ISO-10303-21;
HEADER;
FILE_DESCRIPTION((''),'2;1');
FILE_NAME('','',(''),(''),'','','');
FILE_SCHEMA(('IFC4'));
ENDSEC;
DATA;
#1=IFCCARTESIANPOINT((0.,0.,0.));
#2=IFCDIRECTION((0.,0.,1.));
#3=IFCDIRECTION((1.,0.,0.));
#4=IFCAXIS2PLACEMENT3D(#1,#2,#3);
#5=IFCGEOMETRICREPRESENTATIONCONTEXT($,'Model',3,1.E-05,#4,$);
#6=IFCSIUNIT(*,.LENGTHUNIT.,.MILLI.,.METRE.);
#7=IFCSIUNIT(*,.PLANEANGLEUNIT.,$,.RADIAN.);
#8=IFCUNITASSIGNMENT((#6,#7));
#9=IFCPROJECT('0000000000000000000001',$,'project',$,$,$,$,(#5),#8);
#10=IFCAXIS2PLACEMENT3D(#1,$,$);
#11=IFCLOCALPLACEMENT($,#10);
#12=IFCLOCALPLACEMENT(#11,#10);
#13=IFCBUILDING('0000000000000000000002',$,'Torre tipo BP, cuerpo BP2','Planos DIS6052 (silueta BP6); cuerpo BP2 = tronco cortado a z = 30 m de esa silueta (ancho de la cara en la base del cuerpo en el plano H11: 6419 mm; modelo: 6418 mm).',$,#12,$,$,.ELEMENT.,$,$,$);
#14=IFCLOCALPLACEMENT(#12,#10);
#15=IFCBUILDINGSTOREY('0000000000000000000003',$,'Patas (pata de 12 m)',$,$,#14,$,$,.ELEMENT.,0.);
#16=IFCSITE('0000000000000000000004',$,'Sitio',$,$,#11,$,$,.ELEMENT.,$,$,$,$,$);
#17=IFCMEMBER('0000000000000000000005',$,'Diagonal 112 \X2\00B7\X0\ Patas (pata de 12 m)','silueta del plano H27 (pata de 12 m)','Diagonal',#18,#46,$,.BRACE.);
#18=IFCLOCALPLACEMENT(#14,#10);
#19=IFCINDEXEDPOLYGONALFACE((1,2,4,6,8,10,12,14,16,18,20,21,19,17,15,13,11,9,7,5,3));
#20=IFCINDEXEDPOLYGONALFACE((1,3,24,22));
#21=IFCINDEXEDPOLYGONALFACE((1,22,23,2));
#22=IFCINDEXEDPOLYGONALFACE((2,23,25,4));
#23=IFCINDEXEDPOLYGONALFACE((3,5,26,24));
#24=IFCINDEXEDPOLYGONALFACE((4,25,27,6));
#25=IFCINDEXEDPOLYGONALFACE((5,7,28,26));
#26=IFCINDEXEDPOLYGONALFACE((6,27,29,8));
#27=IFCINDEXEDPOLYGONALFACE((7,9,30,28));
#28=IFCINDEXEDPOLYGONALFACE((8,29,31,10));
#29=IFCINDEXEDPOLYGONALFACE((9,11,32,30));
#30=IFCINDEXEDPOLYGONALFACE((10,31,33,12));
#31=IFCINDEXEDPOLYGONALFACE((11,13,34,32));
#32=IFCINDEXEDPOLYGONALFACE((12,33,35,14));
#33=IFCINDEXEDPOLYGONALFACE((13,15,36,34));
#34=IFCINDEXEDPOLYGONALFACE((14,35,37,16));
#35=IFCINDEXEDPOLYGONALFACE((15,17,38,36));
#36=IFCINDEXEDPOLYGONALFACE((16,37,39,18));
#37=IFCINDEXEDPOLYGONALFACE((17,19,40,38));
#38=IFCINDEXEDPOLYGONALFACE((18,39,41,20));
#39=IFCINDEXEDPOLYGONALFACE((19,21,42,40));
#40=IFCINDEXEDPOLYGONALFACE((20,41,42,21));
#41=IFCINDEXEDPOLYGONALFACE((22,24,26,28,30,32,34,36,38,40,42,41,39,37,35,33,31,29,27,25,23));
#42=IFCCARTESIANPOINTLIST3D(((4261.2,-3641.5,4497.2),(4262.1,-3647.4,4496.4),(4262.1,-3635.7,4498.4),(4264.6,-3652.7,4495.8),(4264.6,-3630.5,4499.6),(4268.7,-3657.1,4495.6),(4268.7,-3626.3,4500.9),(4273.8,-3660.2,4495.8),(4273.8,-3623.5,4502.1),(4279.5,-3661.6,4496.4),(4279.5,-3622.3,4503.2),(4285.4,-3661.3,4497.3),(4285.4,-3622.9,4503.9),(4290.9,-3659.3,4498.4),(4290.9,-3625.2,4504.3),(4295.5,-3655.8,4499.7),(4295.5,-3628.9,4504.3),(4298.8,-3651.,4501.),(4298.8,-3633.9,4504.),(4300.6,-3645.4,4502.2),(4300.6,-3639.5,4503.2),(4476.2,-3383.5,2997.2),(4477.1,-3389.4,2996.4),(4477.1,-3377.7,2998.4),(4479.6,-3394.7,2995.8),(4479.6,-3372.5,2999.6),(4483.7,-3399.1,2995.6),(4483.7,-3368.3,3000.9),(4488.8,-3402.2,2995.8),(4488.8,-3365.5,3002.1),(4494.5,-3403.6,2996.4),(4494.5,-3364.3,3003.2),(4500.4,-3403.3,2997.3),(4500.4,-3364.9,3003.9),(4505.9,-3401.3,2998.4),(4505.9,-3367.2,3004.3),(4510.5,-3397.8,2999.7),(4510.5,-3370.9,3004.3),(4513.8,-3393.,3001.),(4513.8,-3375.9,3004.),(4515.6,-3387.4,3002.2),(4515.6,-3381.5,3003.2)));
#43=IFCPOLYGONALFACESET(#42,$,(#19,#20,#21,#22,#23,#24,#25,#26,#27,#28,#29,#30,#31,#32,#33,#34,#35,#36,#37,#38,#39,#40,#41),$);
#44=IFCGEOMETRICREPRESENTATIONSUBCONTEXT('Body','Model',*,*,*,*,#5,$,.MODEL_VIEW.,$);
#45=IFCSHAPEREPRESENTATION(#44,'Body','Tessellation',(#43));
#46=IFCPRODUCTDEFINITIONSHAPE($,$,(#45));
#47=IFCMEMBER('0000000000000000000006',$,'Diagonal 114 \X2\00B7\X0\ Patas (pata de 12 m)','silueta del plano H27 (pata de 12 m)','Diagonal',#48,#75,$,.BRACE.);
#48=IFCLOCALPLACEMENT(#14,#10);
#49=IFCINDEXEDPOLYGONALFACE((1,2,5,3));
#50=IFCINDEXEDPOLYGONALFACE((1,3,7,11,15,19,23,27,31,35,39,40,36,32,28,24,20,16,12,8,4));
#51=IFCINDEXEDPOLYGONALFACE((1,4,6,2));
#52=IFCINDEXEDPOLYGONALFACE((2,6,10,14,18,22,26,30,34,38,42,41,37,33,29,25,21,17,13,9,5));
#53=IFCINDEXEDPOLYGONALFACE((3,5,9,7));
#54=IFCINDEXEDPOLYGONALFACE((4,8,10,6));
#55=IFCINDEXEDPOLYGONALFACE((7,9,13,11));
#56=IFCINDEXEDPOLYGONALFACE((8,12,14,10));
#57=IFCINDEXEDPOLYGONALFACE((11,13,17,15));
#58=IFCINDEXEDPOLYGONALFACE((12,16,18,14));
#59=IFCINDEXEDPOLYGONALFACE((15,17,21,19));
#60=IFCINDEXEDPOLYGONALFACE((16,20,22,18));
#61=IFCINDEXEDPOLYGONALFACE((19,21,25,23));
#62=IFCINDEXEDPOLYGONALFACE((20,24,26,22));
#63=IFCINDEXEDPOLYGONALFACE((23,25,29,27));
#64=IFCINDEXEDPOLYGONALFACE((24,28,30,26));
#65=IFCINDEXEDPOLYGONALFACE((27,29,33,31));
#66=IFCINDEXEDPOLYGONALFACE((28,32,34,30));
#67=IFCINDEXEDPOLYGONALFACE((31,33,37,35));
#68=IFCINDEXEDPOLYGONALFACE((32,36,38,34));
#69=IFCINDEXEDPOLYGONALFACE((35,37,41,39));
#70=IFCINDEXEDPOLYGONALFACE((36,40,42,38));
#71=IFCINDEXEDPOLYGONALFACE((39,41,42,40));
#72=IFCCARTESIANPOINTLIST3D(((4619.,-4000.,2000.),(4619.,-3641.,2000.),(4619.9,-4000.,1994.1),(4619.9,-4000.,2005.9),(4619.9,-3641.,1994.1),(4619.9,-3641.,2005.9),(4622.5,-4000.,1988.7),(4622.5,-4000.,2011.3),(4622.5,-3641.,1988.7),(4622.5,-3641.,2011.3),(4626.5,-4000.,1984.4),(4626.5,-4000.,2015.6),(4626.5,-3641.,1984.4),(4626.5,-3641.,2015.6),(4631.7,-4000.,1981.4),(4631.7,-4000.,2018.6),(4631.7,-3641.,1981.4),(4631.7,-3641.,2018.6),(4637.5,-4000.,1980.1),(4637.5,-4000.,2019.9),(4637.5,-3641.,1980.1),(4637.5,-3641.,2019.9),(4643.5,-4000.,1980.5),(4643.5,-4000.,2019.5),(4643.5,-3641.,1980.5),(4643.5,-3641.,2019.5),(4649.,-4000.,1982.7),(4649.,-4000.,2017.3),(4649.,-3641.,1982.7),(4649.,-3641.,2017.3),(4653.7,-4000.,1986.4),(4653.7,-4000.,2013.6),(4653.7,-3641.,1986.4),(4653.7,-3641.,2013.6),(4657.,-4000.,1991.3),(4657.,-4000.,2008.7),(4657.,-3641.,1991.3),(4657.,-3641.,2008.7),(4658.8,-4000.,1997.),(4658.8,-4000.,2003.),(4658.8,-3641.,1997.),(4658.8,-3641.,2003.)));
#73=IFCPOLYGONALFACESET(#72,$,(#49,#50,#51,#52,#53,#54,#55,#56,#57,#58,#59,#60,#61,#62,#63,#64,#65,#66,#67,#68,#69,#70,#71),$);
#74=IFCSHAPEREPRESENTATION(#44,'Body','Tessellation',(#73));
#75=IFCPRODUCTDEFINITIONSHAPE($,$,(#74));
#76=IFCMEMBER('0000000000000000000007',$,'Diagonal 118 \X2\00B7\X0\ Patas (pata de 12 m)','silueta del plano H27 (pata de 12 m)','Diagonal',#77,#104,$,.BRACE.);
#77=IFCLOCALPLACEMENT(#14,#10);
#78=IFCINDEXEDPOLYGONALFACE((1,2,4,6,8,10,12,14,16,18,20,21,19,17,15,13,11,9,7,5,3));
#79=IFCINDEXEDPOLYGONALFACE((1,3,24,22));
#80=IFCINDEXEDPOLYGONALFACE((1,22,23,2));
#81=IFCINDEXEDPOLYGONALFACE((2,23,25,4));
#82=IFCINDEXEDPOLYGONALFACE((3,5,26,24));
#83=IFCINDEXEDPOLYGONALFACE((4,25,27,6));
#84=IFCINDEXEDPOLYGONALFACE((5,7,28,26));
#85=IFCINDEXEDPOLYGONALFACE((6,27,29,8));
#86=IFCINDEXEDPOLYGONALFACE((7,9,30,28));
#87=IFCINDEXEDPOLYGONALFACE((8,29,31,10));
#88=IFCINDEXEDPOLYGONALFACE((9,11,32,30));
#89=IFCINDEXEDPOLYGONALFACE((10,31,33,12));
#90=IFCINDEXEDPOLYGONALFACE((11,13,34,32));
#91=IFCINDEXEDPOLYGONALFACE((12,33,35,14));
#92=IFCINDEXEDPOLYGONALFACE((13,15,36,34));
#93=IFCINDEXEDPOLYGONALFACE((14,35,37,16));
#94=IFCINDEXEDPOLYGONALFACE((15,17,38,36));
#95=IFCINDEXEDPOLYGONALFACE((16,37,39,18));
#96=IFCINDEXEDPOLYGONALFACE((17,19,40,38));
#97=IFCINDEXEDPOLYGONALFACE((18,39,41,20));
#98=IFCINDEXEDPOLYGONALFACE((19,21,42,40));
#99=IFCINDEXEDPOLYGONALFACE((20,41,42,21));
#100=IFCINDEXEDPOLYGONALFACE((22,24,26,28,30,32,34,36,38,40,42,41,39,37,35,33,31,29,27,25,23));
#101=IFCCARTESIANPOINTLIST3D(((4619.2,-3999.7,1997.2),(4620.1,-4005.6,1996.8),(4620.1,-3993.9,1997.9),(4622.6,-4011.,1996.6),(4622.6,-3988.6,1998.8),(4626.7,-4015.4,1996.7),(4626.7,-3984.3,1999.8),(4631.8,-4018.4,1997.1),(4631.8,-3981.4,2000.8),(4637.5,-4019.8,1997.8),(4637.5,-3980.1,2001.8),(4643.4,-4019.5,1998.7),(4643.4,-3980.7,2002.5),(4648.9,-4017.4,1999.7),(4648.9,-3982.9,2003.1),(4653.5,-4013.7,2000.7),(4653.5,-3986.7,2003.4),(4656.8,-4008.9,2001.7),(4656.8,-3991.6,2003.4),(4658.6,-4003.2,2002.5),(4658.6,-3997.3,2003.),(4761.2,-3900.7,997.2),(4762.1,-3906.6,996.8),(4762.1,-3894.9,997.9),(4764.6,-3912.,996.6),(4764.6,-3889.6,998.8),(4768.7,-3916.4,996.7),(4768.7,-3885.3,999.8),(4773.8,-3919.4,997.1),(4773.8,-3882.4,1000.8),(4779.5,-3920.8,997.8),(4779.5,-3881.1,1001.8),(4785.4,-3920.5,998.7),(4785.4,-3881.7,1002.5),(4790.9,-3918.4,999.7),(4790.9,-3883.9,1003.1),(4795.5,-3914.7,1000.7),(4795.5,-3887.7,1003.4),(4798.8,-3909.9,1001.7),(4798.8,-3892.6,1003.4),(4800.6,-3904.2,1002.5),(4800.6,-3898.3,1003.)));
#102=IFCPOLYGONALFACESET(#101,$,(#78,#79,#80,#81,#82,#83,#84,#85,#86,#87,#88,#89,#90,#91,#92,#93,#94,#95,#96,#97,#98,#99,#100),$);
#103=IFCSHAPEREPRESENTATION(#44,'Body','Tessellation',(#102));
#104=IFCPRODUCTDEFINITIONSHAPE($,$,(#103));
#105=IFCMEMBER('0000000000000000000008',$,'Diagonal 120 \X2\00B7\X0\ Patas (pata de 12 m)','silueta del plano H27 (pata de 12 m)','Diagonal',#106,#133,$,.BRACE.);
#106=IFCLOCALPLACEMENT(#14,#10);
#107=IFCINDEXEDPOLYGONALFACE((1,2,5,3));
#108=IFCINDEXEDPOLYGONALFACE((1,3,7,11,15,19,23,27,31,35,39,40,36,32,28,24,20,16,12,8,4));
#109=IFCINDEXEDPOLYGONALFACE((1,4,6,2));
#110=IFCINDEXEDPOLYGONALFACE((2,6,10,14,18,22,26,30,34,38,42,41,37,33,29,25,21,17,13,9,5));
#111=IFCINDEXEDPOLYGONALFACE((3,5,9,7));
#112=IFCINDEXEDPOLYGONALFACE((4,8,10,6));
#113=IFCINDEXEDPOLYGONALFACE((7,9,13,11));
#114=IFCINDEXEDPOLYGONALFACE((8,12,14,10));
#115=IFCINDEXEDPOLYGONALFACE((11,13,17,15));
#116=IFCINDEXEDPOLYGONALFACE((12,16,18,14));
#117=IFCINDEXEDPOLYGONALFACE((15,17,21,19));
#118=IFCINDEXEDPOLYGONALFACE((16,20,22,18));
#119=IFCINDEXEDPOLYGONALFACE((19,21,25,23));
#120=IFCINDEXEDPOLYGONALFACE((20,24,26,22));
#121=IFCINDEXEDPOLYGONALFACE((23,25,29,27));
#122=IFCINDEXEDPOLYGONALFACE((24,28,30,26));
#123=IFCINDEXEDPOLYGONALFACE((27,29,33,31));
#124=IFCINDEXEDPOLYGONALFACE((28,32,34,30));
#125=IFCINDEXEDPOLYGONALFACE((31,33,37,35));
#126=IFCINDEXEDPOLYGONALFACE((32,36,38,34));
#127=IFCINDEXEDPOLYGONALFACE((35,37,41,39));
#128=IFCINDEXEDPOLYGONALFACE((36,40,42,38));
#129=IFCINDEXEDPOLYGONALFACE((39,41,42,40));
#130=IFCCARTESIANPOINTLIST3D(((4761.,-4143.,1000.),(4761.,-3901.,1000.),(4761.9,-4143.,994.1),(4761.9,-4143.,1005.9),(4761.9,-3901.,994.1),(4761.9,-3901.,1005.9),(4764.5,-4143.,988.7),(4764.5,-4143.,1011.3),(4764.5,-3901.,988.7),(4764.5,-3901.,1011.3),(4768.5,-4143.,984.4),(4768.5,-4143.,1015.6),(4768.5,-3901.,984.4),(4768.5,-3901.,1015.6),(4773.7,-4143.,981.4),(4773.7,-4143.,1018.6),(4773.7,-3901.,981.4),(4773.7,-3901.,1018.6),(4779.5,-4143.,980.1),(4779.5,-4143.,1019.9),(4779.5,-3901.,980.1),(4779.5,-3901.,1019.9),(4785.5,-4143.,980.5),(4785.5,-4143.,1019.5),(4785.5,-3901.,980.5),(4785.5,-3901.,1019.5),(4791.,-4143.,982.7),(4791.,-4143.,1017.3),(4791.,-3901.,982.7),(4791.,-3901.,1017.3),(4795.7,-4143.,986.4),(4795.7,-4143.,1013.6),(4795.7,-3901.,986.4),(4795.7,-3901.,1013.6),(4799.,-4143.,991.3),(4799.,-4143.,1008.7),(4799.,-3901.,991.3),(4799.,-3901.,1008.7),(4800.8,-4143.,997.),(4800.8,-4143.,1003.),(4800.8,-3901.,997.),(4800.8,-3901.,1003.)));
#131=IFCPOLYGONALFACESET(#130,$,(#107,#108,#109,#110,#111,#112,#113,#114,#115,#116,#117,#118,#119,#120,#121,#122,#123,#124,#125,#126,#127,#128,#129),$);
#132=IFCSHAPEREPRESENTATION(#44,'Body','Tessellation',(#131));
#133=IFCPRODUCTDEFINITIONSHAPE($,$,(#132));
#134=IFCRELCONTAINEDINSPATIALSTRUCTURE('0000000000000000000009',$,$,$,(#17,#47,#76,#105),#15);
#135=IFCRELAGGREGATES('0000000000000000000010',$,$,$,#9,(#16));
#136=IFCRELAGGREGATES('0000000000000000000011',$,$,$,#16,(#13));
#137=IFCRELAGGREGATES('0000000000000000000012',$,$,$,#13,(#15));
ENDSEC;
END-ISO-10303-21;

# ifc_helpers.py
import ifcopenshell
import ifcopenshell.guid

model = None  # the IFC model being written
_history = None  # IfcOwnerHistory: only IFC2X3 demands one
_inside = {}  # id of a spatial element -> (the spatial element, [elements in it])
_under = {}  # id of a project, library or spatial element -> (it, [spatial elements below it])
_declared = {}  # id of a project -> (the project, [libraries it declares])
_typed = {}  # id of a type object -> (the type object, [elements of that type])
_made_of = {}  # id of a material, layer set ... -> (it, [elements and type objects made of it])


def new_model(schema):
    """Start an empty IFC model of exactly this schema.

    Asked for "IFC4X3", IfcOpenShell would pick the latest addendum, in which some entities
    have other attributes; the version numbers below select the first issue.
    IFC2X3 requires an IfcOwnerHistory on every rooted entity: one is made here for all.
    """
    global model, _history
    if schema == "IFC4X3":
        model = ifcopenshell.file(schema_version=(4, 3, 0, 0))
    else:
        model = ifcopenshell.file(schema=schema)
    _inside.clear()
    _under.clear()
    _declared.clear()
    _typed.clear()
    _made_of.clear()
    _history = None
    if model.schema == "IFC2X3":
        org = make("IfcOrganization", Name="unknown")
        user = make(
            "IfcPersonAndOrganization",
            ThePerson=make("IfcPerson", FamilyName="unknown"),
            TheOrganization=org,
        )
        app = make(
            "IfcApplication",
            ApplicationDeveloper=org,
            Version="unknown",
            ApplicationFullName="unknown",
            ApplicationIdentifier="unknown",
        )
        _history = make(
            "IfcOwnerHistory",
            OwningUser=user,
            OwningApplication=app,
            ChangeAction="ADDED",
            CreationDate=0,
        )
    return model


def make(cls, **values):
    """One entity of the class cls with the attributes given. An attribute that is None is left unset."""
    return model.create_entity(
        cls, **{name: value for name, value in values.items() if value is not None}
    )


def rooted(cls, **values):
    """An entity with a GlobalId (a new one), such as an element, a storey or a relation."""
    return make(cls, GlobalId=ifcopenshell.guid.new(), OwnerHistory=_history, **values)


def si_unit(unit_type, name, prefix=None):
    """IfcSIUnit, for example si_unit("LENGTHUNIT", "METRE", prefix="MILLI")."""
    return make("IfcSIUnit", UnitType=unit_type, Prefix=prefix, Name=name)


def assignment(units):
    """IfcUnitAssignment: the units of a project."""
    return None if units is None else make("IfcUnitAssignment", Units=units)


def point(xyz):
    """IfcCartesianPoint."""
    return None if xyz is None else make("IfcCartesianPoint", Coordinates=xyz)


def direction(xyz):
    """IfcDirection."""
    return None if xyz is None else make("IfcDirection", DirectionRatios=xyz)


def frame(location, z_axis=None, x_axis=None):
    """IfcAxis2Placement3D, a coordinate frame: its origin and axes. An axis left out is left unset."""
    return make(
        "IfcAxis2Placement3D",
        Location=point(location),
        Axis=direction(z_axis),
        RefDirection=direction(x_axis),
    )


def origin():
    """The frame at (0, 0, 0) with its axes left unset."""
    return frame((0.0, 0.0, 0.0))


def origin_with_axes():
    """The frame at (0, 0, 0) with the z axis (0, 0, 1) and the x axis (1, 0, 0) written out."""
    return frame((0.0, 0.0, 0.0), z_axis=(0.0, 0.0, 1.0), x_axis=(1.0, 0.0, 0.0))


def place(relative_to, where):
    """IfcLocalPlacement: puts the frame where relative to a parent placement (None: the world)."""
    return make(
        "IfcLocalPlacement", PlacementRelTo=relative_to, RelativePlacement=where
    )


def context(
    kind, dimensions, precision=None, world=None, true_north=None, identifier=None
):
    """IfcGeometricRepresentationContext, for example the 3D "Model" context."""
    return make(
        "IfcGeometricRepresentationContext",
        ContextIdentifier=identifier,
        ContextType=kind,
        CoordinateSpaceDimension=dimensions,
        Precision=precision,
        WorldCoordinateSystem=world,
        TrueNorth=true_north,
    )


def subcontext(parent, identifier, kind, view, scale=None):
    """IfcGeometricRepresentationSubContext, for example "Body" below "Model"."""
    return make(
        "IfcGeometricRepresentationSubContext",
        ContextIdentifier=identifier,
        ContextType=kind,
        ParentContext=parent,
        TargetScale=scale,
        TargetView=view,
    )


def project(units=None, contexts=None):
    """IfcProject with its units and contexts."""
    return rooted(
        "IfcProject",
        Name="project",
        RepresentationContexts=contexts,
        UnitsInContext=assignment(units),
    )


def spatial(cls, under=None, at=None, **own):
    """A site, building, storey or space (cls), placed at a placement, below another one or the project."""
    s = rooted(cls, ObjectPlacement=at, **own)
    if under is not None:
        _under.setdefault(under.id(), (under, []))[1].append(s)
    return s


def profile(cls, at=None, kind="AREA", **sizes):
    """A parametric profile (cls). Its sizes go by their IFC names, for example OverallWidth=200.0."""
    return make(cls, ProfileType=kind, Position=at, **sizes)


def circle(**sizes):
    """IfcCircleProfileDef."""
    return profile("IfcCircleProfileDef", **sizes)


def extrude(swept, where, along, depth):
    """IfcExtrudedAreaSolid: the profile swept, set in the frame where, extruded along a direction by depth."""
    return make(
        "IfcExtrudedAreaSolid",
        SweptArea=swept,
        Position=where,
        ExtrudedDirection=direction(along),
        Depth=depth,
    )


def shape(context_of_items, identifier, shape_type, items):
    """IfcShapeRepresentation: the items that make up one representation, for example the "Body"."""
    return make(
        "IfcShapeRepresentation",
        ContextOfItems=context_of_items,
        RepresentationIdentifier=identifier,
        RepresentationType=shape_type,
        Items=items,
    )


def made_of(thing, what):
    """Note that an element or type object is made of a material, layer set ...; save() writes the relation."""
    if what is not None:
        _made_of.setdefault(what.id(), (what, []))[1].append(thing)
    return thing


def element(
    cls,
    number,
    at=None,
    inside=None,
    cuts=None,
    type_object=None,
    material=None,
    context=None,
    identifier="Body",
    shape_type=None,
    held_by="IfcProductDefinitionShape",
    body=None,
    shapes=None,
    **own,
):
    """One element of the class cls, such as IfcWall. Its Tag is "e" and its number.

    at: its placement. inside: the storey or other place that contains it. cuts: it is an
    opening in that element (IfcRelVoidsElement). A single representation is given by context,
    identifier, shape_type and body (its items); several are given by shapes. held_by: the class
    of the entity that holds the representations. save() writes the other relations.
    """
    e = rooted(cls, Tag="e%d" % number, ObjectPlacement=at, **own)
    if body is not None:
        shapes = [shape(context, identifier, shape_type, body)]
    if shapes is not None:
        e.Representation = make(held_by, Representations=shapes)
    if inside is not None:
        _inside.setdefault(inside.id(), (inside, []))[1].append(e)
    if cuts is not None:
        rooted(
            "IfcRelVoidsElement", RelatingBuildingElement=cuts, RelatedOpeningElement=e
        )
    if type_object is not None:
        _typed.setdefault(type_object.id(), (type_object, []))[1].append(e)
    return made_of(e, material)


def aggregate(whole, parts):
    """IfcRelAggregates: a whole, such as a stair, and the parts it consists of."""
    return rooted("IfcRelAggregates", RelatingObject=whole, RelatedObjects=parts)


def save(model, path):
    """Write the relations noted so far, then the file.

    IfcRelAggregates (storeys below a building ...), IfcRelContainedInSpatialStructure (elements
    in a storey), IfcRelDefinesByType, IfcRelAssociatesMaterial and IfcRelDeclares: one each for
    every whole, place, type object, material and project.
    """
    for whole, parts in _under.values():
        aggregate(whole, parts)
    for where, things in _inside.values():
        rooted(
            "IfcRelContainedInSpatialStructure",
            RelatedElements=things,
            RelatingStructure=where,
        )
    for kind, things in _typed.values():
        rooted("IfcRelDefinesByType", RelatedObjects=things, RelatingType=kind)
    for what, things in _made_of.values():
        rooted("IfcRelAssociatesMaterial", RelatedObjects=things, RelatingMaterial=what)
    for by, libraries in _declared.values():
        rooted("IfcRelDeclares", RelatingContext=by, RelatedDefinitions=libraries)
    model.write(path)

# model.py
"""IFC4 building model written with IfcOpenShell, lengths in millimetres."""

from ifc_helpers import new_model, si_unit, frame, origin, origin_with_axes, place, context, subcontext, project, spatial, circle, extrude, element, save


model = new_model("IFC4")

# Units and contexts
model_context = context("Model", 3, precision=1e-05, world=origin_with_axes())
body_context = subcontext(model_context, "Body", "Model", "MODEL_VIEW")
ifc_project = project(units=[si_unit("LENGTHUNIT", "METRE", prefix="MILLI"), si_unit("PLANEANGLEUNIT", "RADIAN")], contexts=[model_context])

# Site, building, storey
site_placement = place(None, origin())
site = spatial("IfcSite", under=ifc_project, at=site_placement, Name="Sitio", CompositionType="ELEMENT")
building_placement = place(site_placement, origin())
building = spatial("IfcBuilding", under=site, at=building_placement, Name="Torre tipo BP, cuerpo BP2", Description="Planos DIS6052 (silueta BP6); cuerpo BP2 = tronco cortado a z = 30 m de esa silueta (ancho de la cara en la base del cuerpo en el plano H11: 6419 mm; modelo: 6418 mm).", CompositionType="ELEMENT")
storey_placement = place(building_placement, origin())
storey = spatial("IfcBuildingStorey", under=building, at=storey_placement, Name="Patas (pata de 12 m)", CompositionType="ELEMENT", Elevation=0.0)

# Members
member_1_placement = place(storey_placement, frame((4496.0, -3384.0, 3000.0), z_axis=(-0.13987, -0.167845, 0.97584), x_axis=(-0.99017, 0.02371, -0.137846)))
element("IfcMember", 1, at=member_1_placement, inside=storey, Name="Diagonal 112 · Patas (pata de 12 m)", Description="silueta del plano H27 (pata de 12 m)", ObjectType="Diagonal", PredefinedType="BRACE", context=body_context, shape_type="SweptSolid", body=[
    extrude(circle(Radius=20.0), None, (0.0, 0.0, 1.0), 1537.1),
])
member_2_placement = place(storey_placement, frame((4639.0, -4000.0, 2000.0), z_axis=(0.0, 1.0, 0.0), x_axis=(-1.0, 0.0, 0.0)))
element("IfcMember", 2, at=member_2_placement, inside=storey, Name="Diagonal 114 · Patas (pata de 12 m)", Description="silueta del plano H27 (pata de 12 m)", ObjectType="Diagonal", PredefinedType="BRACE", context=body_context, shape_type="SweptSolid", body=[
    extrude(circle(Radius=20.0), None, (0.0, 0.0, 1.0), 359.0),
])
member_3_placement = place(storey_placement, frame((4781.0, -3901.0, 1000.0), z_axis=(-0.139919, -0.097549, 0.985346), x_axis=(-0.990163, 0.013785, -0.139238)))
element("IfcMember", 3, at=member_3_placement, inside=storey, Name="Diagonal 118 · Patas (pata de 12 m)", Description="silueta del plano H27 (pata de 12 m)", ObjectType="Diagonal", PredefinedType="BRACE", context=body_context, shape_type="SweptSolid", body=[
    extrude(circle(Radius=20.0), None, (0.0, 0.0, 1.0), 1014.9),
])
member_4_placement = place(storey_placement, frame((4781.0, -4143.0, 1000.0), z_axis=(0.0, 1.0, 0.0), x_axis=(-1.0, 0.0, 0.0)))
element("IfcMember", 4, at=member_4_placement, inside=storey, Name="Diagonal 120 · Patas (pata de 12 m)", Description="silueta del plano H27 (pata de 12 m)", ObjectType="Diagonal", PredefinedType="BRACE", context=body_context, shape_type="SweptSolid", body=[
    extrude(circle(Radius=20.0), None, (0.0, 0.0, 1.0), 242.0),
])

save(model, "model.ifc")
